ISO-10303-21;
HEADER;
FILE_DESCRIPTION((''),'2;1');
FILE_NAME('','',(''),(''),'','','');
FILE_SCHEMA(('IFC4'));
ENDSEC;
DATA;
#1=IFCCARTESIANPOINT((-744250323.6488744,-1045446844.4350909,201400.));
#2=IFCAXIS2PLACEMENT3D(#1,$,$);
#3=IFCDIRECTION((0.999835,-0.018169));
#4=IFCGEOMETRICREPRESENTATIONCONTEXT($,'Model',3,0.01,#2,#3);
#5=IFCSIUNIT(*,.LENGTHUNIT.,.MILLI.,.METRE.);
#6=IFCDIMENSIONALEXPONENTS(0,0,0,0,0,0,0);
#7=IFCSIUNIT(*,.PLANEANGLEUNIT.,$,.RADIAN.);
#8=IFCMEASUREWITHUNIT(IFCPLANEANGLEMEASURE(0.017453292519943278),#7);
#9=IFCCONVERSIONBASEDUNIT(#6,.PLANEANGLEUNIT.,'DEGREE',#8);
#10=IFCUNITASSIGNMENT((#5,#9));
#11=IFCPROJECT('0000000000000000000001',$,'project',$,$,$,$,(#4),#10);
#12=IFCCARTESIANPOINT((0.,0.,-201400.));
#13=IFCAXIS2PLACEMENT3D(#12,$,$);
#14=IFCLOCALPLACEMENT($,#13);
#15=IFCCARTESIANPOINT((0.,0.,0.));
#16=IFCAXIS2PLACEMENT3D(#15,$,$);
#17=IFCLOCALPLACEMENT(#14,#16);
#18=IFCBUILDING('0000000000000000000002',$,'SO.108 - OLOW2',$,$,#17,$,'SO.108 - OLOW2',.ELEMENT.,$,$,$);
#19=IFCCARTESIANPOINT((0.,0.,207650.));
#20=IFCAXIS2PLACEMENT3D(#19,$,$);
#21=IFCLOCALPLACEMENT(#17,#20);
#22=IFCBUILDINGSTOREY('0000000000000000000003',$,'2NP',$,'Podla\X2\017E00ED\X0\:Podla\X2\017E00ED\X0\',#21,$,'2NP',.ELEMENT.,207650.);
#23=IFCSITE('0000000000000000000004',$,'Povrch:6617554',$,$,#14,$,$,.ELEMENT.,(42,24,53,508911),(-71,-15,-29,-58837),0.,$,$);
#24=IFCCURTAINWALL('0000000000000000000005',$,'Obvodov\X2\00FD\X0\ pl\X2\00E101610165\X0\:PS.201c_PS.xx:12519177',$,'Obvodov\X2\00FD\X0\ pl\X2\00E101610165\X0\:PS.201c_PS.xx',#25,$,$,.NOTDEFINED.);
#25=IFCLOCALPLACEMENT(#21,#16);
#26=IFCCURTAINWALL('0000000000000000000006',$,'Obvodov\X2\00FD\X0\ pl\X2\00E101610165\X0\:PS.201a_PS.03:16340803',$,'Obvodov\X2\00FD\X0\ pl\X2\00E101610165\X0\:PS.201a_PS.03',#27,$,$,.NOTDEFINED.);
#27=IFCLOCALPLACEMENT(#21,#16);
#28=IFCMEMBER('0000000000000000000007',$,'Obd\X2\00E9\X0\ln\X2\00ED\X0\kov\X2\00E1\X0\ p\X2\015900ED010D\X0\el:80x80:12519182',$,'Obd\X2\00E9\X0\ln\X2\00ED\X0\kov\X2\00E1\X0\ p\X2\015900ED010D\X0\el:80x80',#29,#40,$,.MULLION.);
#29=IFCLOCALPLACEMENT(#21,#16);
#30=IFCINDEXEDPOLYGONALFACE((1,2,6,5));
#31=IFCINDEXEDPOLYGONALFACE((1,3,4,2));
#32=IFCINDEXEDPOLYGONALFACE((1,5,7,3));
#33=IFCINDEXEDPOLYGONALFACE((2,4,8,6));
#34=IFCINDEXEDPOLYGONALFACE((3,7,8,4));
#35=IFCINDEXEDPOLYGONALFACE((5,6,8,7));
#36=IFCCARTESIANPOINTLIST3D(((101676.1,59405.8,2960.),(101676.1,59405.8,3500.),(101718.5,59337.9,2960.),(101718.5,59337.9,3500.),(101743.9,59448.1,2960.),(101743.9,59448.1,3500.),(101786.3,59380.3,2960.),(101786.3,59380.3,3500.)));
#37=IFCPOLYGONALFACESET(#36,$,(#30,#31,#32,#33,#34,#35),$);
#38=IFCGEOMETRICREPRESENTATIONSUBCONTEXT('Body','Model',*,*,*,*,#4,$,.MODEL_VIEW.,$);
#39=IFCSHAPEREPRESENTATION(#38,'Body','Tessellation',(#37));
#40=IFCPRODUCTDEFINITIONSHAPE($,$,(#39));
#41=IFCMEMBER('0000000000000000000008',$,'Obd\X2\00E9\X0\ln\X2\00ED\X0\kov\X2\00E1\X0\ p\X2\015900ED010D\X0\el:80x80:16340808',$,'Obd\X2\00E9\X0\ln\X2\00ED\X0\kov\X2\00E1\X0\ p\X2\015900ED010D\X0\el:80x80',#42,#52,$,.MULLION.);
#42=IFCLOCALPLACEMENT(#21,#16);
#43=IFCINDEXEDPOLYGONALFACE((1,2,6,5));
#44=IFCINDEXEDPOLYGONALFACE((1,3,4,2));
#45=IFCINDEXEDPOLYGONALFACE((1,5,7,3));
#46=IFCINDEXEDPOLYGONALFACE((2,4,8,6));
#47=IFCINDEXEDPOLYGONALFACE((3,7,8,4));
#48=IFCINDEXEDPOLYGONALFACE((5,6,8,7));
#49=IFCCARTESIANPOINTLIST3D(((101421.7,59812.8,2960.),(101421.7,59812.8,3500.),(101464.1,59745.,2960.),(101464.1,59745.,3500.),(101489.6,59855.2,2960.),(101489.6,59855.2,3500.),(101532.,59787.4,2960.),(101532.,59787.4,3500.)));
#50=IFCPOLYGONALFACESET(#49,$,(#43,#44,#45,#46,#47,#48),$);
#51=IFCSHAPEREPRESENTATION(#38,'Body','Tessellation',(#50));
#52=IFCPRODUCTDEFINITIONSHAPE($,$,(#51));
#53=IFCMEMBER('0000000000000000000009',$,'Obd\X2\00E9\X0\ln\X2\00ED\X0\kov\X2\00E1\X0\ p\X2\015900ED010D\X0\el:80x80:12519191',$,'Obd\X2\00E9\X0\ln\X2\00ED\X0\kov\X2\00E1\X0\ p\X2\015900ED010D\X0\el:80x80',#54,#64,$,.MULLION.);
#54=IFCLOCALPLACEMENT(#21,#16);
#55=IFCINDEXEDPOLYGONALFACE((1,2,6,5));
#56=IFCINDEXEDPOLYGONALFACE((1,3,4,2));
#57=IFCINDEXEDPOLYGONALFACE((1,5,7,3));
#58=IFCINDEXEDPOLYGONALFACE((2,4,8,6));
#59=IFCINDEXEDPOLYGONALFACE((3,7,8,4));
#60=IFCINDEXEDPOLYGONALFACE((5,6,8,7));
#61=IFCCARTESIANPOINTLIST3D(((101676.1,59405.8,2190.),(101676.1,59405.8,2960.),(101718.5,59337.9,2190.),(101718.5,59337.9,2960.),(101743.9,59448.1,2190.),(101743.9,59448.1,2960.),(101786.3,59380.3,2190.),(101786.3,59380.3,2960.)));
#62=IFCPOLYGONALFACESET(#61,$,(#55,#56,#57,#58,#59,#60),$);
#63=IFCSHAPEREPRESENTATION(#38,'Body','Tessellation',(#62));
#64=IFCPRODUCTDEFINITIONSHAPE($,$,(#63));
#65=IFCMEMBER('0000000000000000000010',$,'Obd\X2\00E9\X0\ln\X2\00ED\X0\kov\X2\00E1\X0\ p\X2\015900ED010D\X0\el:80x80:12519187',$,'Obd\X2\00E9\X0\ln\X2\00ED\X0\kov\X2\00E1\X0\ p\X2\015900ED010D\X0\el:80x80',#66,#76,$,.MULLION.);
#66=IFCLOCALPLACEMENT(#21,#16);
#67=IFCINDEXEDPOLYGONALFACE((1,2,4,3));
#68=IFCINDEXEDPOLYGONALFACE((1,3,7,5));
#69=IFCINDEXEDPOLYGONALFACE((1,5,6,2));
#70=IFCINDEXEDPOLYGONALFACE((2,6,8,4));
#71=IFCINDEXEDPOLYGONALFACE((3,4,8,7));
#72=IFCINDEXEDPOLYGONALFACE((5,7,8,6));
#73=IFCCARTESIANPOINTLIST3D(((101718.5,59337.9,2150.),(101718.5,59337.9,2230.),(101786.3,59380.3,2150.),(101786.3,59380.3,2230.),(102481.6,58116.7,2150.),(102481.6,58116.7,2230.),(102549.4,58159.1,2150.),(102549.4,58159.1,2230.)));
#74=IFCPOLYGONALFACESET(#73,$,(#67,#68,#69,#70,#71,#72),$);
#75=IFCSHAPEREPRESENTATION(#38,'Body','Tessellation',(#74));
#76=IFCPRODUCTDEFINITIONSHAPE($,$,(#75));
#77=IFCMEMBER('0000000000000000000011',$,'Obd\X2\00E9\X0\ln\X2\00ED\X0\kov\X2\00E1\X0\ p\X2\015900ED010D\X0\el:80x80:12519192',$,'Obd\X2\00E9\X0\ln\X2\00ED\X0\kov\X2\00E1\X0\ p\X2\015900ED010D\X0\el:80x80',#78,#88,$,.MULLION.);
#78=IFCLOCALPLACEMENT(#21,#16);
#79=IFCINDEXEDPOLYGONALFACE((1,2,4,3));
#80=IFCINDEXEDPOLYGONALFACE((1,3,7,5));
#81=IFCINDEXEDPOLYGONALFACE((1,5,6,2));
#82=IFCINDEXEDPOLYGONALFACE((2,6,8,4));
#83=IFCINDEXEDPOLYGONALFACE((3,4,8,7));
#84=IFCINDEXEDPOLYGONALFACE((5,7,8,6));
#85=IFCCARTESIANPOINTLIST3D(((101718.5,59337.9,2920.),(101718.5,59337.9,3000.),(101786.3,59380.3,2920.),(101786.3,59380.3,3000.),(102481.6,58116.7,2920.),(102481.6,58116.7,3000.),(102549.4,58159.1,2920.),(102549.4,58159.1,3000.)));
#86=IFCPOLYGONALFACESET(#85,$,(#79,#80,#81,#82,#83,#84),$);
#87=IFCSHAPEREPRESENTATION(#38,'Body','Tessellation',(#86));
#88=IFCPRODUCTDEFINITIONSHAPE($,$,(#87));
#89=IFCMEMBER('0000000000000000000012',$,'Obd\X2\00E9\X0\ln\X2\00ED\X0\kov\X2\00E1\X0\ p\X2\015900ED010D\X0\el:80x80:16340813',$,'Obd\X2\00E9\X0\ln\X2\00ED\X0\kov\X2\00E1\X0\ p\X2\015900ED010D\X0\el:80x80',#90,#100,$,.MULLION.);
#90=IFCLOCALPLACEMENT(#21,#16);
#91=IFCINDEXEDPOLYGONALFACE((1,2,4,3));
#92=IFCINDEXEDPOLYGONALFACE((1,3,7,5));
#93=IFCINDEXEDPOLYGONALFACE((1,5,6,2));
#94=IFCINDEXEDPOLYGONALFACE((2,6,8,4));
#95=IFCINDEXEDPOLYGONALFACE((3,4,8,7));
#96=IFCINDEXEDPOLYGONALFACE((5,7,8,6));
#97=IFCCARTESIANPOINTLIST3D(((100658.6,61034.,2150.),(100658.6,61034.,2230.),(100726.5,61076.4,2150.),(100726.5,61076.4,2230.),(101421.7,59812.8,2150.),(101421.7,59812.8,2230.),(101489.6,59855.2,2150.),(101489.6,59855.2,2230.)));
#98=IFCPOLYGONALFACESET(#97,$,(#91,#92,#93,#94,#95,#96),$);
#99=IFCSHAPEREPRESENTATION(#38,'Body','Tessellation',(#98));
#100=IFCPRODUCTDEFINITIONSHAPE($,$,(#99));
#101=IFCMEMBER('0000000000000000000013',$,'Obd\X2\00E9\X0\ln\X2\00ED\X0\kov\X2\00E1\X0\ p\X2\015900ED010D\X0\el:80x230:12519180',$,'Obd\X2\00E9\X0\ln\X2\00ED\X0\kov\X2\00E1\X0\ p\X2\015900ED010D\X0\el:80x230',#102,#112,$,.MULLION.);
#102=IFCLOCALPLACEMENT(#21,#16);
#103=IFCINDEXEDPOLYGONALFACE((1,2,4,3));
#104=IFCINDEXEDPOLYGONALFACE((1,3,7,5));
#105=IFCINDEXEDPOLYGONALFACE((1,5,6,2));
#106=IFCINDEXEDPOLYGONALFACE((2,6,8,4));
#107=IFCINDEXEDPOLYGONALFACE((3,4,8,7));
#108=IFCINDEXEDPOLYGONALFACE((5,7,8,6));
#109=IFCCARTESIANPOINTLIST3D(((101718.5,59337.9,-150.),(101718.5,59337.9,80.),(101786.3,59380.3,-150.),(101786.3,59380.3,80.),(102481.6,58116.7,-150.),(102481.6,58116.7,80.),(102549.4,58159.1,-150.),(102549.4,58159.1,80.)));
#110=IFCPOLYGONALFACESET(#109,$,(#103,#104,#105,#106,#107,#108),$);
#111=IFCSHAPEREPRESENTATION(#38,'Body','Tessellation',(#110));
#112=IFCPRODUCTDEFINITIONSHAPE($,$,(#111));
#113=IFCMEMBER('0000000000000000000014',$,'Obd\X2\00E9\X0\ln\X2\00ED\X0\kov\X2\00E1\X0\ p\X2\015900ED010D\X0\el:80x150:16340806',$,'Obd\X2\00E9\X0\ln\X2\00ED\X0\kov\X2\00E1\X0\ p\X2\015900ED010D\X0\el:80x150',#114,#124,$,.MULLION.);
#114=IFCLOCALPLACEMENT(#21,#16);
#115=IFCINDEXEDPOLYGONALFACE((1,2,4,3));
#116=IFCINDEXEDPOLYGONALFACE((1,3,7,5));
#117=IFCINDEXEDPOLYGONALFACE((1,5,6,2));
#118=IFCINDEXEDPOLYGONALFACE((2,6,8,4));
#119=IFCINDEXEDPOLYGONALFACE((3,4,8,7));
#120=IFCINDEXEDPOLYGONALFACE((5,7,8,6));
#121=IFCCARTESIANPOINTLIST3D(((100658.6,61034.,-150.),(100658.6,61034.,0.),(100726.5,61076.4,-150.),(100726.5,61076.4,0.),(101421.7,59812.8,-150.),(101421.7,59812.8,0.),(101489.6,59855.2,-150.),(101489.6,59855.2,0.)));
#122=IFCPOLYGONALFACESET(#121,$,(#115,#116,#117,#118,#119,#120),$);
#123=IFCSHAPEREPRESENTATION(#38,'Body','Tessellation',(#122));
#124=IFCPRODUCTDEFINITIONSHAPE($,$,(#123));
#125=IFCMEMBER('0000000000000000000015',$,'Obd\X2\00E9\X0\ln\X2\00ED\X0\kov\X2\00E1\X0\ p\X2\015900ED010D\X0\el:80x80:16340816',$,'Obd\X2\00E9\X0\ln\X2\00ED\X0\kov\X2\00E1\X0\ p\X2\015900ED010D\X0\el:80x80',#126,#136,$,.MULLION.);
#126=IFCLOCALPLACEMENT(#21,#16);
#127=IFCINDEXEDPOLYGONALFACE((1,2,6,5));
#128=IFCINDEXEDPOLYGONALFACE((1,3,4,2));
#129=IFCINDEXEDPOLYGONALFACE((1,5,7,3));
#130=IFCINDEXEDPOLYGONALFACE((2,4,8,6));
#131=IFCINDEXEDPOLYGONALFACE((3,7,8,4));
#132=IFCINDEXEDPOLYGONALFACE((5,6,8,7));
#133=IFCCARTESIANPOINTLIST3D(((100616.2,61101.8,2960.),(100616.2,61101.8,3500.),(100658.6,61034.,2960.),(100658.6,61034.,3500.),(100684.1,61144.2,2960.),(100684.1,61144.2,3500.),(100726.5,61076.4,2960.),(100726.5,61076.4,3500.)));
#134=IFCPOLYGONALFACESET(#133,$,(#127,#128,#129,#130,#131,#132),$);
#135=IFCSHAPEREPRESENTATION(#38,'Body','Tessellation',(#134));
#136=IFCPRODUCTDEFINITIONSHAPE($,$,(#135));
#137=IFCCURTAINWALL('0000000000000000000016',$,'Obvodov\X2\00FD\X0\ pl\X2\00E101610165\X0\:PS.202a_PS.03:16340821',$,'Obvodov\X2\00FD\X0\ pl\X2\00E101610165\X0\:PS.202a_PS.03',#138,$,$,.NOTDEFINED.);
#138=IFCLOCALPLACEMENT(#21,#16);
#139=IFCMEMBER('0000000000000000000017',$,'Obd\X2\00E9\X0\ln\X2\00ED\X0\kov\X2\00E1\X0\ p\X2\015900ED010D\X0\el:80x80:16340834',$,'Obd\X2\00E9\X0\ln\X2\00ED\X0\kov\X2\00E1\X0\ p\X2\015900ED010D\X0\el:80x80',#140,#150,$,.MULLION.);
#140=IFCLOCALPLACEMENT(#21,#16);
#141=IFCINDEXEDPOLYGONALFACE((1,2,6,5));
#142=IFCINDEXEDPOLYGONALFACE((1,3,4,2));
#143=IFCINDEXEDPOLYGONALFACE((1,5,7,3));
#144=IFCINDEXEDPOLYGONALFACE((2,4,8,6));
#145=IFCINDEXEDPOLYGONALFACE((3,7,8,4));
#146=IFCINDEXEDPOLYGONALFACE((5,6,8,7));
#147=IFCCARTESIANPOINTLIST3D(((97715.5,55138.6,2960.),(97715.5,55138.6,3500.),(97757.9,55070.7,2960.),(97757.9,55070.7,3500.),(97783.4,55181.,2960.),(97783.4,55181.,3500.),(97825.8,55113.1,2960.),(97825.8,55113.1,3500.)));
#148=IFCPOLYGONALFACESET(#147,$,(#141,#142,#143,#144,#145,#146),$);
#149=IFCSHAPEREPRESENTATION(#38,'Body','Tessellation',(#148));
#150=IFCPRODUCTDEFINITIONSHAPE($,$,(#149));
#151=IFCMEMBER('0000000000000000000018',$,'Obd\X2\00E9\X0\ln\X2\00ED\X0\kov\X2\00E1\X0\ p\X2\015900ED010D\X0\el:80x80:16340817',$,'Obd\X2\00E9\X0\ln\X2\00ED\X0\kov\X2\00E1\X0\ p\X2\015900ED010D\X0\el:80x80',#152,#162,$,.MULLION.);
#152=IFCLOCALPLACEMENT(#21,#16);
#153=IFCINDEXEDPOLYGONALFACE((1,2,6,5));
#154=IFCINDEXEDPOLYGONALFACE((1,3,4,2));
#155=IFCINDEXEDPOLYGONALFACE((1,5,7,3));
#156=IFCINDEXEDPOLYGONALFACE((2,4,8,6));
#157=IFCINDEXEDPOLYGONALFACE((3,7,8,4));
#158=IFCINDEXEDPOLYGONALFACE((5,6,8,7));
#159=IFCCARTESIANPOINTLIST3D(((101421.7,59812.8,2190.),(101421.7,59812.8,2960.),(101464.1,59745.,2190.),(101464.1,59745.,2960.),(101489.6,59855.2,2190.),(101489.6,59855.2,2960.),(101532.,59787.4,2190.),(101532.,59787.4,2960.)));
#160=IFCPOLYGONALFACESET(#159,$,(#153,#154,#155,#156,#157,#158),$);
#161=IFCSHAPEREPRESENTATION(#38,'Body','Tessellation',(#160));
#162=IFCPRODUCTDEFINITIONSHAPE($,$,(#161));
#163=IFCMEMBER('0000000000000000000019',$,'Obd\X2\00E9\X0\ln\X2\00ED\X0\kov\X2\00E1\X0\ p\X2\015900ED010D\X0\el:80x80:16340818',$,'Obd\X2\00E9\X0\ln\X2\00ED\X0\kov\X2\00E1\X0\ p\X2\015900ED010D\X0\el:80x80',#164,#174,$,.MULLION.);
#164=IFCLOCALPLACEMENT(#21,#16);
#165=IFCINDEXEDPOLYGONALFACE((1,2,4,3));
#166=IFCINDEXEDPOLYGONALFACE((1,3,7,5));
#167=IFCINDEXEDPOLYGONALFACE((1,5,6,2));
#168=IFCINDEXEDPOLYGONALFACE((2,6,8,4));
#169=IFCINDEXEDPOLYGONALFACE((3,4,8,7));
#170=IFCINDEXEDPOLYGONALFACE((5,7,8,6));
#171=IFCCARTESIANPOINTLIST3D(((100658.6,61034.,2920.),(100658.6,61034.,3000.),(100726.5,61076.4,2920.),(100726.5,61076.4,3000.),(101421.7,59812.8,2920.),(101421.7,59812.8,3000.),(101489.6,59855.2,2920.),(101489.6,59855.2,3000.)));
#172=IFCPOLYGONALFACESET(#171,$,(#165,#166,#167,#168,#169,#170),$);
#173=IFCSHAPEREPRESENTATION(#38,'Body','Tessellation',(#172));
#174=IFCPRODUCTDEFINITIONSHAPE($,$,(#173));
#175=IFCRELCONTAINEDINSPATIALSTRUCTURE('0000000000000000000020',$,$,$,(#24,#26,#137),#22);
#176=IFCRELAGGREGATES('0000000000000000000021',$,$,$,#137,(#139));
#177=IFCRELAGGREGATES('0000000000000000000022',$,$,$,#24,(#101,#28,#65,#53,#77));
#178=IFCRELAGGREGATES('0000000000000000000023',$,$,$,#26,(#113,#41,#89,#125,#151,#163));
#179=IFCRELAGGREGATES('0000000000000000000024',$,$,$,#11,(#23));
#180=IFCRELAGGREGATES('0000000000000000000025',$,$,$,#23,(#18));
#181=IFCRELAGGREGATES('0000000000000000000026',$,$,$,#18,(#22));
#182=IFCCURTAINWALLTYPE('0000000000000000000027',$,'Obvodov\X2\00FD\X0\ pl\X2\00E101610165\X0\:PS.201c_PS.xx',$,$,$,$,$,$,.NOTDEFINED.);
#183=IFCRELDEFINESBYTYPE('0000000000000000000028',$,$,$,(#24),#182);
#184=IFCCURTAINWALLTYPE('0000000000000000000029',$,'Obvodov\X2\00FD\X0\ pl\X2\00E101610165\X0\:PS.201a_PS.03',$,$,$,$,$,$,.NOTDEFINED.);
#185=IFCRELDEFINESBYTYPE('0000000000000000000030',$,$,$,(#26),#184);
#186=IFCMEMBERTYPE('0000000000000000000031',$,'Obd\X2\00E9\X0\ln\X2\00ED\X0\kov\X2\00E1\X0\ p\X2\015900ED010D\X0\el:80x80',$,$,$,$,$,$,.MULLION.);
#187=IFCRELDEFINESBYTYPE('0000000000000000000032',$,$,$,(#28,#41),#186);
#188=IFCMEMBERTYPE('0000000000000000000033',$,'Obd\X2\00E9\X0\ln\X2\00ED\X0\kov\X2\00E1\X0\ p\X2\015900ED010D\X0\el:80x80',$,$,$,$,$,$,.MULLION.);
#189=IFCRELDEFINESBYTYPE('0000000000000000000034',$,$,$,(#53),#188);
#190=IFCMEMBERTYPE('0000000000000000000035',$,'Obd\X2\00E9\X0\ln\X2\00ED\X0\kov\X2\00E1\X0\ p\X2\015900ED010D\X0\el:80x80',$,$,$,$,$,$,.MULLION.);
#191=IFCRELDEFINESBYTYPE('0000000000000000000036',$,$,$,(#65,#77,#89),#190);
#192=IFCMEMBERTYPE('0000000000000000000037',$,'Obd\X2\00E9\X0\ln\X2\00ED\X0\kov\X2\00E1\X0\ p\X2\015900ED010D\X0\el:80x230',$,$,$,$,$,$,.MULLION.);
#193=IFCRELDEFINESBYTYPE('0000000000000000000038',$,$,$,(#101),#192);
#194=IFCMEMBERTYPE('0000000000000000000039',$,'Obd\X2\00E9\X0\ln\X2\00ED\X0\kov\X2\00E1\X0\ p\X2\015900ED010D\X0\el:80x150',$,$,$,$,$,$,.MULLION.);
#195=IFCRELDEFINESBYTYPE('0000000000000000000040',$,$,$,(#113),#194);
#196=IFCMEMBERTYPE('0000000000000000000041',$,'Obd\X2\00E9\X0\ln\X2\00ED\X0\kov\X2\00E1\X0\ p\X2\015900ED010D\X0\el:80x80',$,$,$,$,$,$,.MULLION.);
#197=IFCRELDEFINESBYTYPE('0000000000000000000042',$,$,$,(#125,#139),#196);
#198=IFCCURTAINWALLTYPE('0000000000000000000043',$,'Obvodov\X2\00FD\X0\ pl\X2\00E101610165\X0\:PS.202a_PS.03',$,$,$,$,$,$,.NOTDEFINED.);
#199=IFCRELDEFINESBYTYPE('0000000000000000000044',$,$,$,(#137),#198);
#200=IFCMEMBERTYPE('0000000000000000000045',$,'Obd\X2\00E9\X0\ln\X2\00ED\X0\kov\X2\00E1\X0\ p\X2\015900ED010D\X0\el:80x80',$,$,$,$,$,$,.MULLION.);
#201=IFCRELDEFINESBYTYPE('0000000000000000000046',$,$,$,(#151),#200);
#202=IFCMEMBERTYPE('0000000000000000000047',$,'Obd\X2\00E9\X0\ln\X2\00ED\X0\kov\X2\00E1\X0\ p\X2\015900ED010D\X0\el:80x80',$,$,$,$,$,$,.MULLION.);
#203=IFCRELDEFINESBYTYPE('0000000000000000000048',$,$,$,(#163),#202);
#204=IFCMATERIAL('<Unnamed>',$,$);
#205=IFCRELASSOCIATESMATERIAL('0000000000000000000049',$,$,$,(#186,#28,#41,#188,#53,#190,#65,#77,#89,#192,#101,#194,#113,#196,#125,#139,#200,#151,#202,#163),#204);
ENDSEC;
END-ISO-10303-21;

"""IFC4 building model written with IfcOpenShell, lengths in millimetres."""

from ifc_helpers import new_model, entity, si_unit, converted_unit, direction, frame, origin, place, context, subcontext, project, spatial, indexed_curve, outline, extrude, source, transform, mapped, material, type_object, type_shapes, element, aggregate, save


model = new_model("IFC4")

# Units and contexts
model_context = context("Model", 3, precision=0.01, world=frame((-744250323.6488744, -1045446844.4350909, 201400.0)), true_north=direction((0.999835, -0.018169)))
body_context = subcontext(model_context, "Body", "Model", "MODEL_VIEW")
ifc_project = project(units=[si_unit("LENGTHUNIT", "METRE", prefix="MILLI"), converted_unit("PLANEANGLEUNIT", "DEGREE", entity("IfcPlaneAngleMeasure", 0.017453292519943278), si_unit("PLANEANGLEUNIT", "RADIAN"), dimensions=[0, 0, 0, 0, 0, 0, 0])], contexts=[model_context])

# Site, building, storey
site_placement = place(None, frame((0.0, 0.0, -201400.0)))
site = spatial("IfcSite", under=ifc_project, at=site_placement, Name="Povrch:6617554", CompositionType="ELEMENT", RefLatitude=(42, 24, 53, 508911), RefLongitude=(-71, -15, -29, -58837), RefElevation=0.0)
building_placement = place(site_placement, origin())
building = spatial("IfcBuilding", under=site, at=building_placement, Name="SO.108 - OLOW2", LongName="SO.108 - OLOW2", CompositionType="ELEMENT")
storey_placement = place(building_placement, frame((0.0, 0.0, 207650.0)))
storey = spatial("IfcBuildingStorey", under=building, at=storey_placement, Name="2NP", ObjectType="Podlaží:Podlaží", LongName="2NP", CompositionType="ELEMENT", Elevation=207650.0)

# Shared definitions
ifc_material_1 = material(Name="<Unnamed>")

# Curtain walls
curtain_wall_type_1 = type_object("IfcCurtainWallType", Name="Obvodový plášť:PS.201c_PS.xx", PredefinedType="NOTDEFINED")
curtain_wall_1_placement = place(storey_placement, frame((0.0, 0.0, -207650.0)))
curtain_wall_1 = element("IfcCurtainWall", 1, at=curtain_wall_1_placement, inside=storey, type_object=curtain_wall_type_1, Name="Obvodový plášť:PS.201c_PS.xx:12519177", ObjectType="Obvodový plášť:PS.201c_PS.xx", PredefinedType="NOTDEFINED")
curtain_wall_type_2 = type_object("IfcCurtainWallType", Name="Obvodový plášť:PS.201a_PS.03", PredefinedType="NOTDEFINED")
curtain_wall_2_placement = place(storey_placement, frame((0.0, 0.0, -207650.0)))
curtain_wall_2 = element("IfcCurtainWall", 2, at=curtain_wall_2_placement, inside=storey, type_object=curtain_wall_type_2, Name="Obvodový plášť:PS.201a_PS.03:16340803", ObjectType="Obvodový plášť:PS.201a_PS.03", PredefinedType="NOTDEFINED")

# Members
member_type_1 = type_object("IfcMemberType", Name="Obdélníková příčel:80x80", PredefinedType="MULLION", material=ifc_material_1)
shared_shape_1 = source(origin(), body_context, "Body", "SweptSolid", [
    extrude(outline(indexed_curve([(-40.0, -40.0), (40.0, -40.0), (40.0, 40.0), (-40.0, 40.0), (-40.0, -40.0)], self_intersect=False)), frame((-40.0, 0.0, -540.0), z_axis=(0.0, 0.0, 1.0), x_axis=(-1.0, 0.0, 0.0)), (0.0, 0.0, 1.0), 540.0),
])
type_shapes(member_type_1, [shared_shape_1])
member_1_placement = place(curtain_wall_1_placement, frame((101710.0, 59426.9, 211150.0), z_axis=(0.0, 0.0, 1.0), x_axis=(-0.529919, 0.848048, 0.0)))
member_1 = element("IfcMember", 3, at=member_1_placement, type_object=member_type_1, material=ifc_material_1, Name="Obdélníková příčel:80x80:12519182", ObjectType="Obdélníková příčel:80x80", PredefinedType="MULLION", context=body_context, shape_type="MappedRepresentation", body=[
    mapped(shared_shape_1, transform((0.0, 0.0, 0.0), scale=1.0)),
])
member_2_placement = place(curtain_wall_2_placement, frame((101498.0, 59766.2, 211150.0), z_axis=(0.0, 0.0, 1.0), x_axis=(0.529919, -0.848048, 0.0)))
member_2 = element("IfcMember", 4, at=member_2_placement, type_object=member_type_1, material=ifc_material_1, Name="Obdélníková příčel:80x80:16340808", ObjectType="Obdélníková příčel:80x80", PredefinedType="MULLION", context=body_context, shape_type="MappedRepresentation", body=[
    mapped(shared_shape_1, transform((0.0, 0.0, 0.0), scale=1.0)),
])
member_type_2 = type_object("IfcMemberType", Name="Obdélníková příčel:80x80", PredefinedType="MULLION", material=ifc_material_1)
shared_shape_2 = source(origin(), body_context, "Body", "SweptSolid", [
    extrude(outline(indexed_curve([(-40.0, -40.0), (40.0, -40.0), (40.0, 40.0), (-40.0, 40.0), (-40.0, -40.0)], self_intersect=False)), frame((-40.0, 0.0, -770.0), z_axis=(0.0, 0.0, 1.0), x_axis=(-1.0, 0.0, 0.0)), (0.0, 0.0, 1.0), 770.0),
])
type_shapes(member_type_2, [shared_shape_2])
member_3_placement = place(curtain_wall_1_placement, frame((101710.0, 59426.9, 210610.0), z_axis=(0.0, 0.0, 1.0), x_axis=(-0.529919, 0.848048, 0.0)))
member_3 = element("IfcMember", 5, at=member_3_placement, type_object=member_type_2, material=ifc_material_1, Name="Obdélníková příčel:80x80:12519191", ObjectType="Obdélníková příčel:80x80", PredefinedType="MULLION", context=body_context, shape_type="MappedRepresentation", body=[
    mapped(shared_shape_2, transform((0.0, 0.0, 0.0), scale=1.0)),
])
member_type_3 = type_object("IfcMemberType", Name="Obdélníková příčel:80x80", PredefinedType="MULLION", material=ifc_material_1)
shared_shape_3 = source(origin(), body_context, "Body", "SweptSolid", [
    extrude(outline(indexed_curve([(-40.0, -40.0), (40.0, -40.0), (40.0, 40.0), (-40.0, 40.0), (-40.0, -40.0)], self_intersect=False)), frame((0.0, 0.0, -1440.0), z_axis=(0.0, 0.0, 1.0), x_axis=(-1.0, 0.0, 0.0)), (0.0, 0.0, 1.0), 1440.0),
])
type_shapes(member_type_3, [shared_shape_3])
member_4_placement = place(curtain_wall_1_placement, frame((102515.5, 58137.9, 209840.0), z_axis=(0.529919, -0.848048, 0.0), x_axis=(0.0, 0.0, 1.0)))
member_4 = element("IfcMember", 6, at=member_4_placement, type_object=member_type_3, material=ifc_material_1, Name="Obdélníková příčel:80x80:12519187", ObjectType="Obdélníková příčel:80x80", PredefinedType="MULLION", context=body_context, shape_type="MappedRepresentation", body=[
    mapped(shared_shape_3, transform((0.0, 0.0, 0.0), scale=1.0)),
])
member_5_placement = place(curtain_wall_1_placement, frame((102515.5, 58137.9, 210610.0), z_axis=(0.529919, -0.848048, 0.0), x_axis=(0.0, 0.0, 1.0)))
member_5 = element("IfcMember", 7, at=member_5_placement, type_object=member_type_3, material=ifc_material_1, Name="Obdélníková příčel:80x80:12519192", ObjectType="Obdélníková příčel:80x80", PredefinedType="MULLION", context=body_context, shape_type="MappedRepresentation", body=[
    mapped(shared_shape_3, transform((0.0, 0.0, 0.0), scale=1.0)),
])
member_6_placement = place(curtain_wall_2_placement, frame((100692.6, 61055.2, 209840.0), z_axis=(-0.529919, 0.848048, 0.0), x_axis=(0.0, 0.0, 1.0)))
member_6 = element("IfcMember", 8, at=member_6_placement, type_object=member_type_3, material=ifc_material_1, Name="Obdélníková příčel:80x80:16340813", ObjectType="Obdélníková příčel:80x80", PredefinedType="MULLION", context=body_context, shape_type="MappedRepresentation", body=[
    mapped(shared_shape_3, transform((0.0, 0.0, 0.0), scale=1.0)),
])
member_type_4 = type_object("IfcMemberType", Name="Obdélníková příčel:80x230", PredefinedType="MULLION", material=ifc_material_1)
shared_shape_4 = source(origin(), body_context, "Body", "SweptSolid", [
    extrude(outline(indexed_curve([(-115.0, -40.0), (115.0, -40.0), (115.0, 40.0), (-115.0, 40.0), (-115.0, -40.0)], self_intersect=False)), frame((-115.0, 0.0, -1440.0), z_axis=(0.0, 0.0, 1.0), x_axis=(-1.0, 0.0, 0.0)), (0.0, 0.0, 1.0), 1440.0),
])
type_shapes(member_type_4, [shared_shape_4])
member_7_placement = place(curtain_wall_1_placement, frame((101752.4, 59359.1, 207500.0), z_axis=(-0.529919, 0.848048, 0.0), x_axis=(0.0, 0.0, -1.0)))
member_7 = element("IfcMember", 9, at=member_7_placement, type_object=member_type_4, material=ifc_material_1, Name="Obdélníková příčel:80x230:12519180", ObjectType="Obdélníková příčel:80x230", PredefinedType="MULLION", context=body_context, shape_type="MappedRepresentation", body=[
    mapped(shared_shape_4, transform((0.0, 0.0, 0.0), scale=1.0)),
])
member_type_5 = type_object("IfcMemberType", Name="Obdélníková příčel:80x150", PredefinedType="MULLION", material=ifc_material_1)
shared_shape_5 = source(origin(), body_context, "Body", "SweptSolid", [
    extrude(outline(indexed_curve([(-75.0, -40.0), (75.0, -40.0), (75.0, 40.0), (-75.0, 40.0), (-75.0, -40.0)], self_intersect=False)), frame((-75.0, 0.0, -1440.0), z_axis=(0.0, 0.0, 1.0), x_axis=(-1.0, 0.0, 0.0)), (0.0, 0.0, 1.0), 1440.0),
])
type_shapes(member_type_5, [shared_shape_5])
member_8_placement = place(curtain_wall_2_placement, frame((101455.6, 59834.0, 207500.0), z_axis=(0.529919, -0.848048, 0.0), x_axis=(0.0, 0.0, -1.0)))
member_8 = element("IfcMember", 10, at=member_8_placement, type_object=member_type_5, material=ifc_material_1, Name="Obdélníková příčel:80x150:16340806", ObjectType="Obdélníková příčel:80x150", PredefinedType="MULLION", context=body_context, shape_type="MappedRepresentation", body=[
    mapped(shared_shape_5, transform((0.0, 0.0, 0.0), scale=1.0)),
])
member_type_6 = type_object("IfcMemberType", Name="Obdélníková příčel:80x80", PredefinedType="MULLION", material=ifc_material_1)
shared_shape_6 = source(origin(), body_context, "Body", "SweptSolid", [
    extrude(outline(indexed_curve([(-40.0, -40.0), (40.0, -40.0), (40.0, 40.0), (-40.0, 40.0), (-40.0, -40.0)], self_intersect=False)), frame((-40.0, 0.0, -540.0), z_axis=(0.0, 0.0, 1.0), x_axis=(-1.0, 0.0, 0.0)), (0.0, 0.0, 1.0), 540.0),
])
type_shapes(member_type_6, [shared_shape_6])
member_9_placement = place(curtain_wall_2_placement, frame((100650.2, 61123.0, 210610.0), z_axis=(0.0, 0.0, -1.0), x_axis=(-0.529919, 0.848048, 0.0)))
member_9 = element("IfcMember", 11, at=member_9_placement, type_object=member_type_6, material=ifc_material_1, Name="Obdélníková příčel:80x80:16340816", ObjectType="Obdélníková příčel:80x80", PredefinedType="MULLION", context=body_context, shape_type="MappedRepresentation", body=[
    mapped(shared_shape_6, transform((0.0, 0.0, 0.0), scale=1.0)),
])

# Curtain wall, member
curtain_wall_type_3 = type_object("IfcCurtainWallType", Name="Obvodový plášť:PS.202a_PS.03", PredefinedType="NOTDEFINED")
curtain_wall_3_placement = place(storey_placement, frame((0.0, 0.0, -207650.0)))
curtain_wall_3 = element("IfcCurtainWall", 12, at=curtain_wall_3_placement, inside=storey, type_object=curtain_wall_type_3, Name="Obvodový plášť:PS.202a_PS.03:16340821", ObjectType="Obvodový plášť:PS.202a_PS.03", PredefinedType="NOTDEFINED")
member_10_placement = place(curtain_wall_3_placement, frame((97791.8, 55091.9, 210610.0), z_axis=(0.0, 0.0, -1.0), x_axis=(0.529919, -0.848048, 0.0)))
member_10 = element("IfcMember", 13, at=member_10_placement, type_object=member_type_6, material=ifc_material_1, Name="Obdélníková příčel:80x80:16340834", ObjectType="Obdélníková příčel:80x80", PredefinedType="MULLION", context=body_context, shape_type="MappedRepresentation", body=[
    mapped(shared_shape_6, transform((0.0, 0.0, 0.0), scale=1.0)),
])
aggregate(curtain_wall_3, [member_10])

# Members
member_type_7 = type_object("IfcMemberType", Name="Obdélníková příčel:80x80", PredefinedType="MULLION", material=ifc_material_1)
shared_shape_7 = source(origin(), body_context, "Body", "SweptSolid", [
    extrude(outline(indexed_curve([(-40.0, -40.0), (40.0, -40.0), (40.0, 40.0), (-40.0, 40.0), (-40.0, -40.0)], self_intersect=False)), frame((-40.0, 0.0, -770.0), z_axis=(0.0, 0.0, 1.0), x_axis=(-1.0, 0.0, 0.0)), (0.0, 0.0, 1.0), 770.0),
])
type_shapes(member_type_7, [shared_shape_7])
member_11_placement = place(curtain_wall_2_placement, frame((101498.0, 59766.2, 210610.0), z_axis=(0.0, 0.0, 1.0), x_axis=(0.529919, -0.848048, 0.0)))
member_11 = element("IfcMember", 14, at=member_11_placement, type_object=member_type_7, material=ifc_material_1, Name="Obdélníková příčel:80x80:16340817", ObjectType="Obdélníková příčel:80x80", PredefinedType="MULLION", context=body_context, shape_type="MappedRepresentation", body=[
    mapped(shared_shape_7, transform((0.0, 0.0, 0.0), scale=1.0)),
])
member_type_8 = type_object("IfcMemberType", Name="Obdélníková příčel:80x80", PredefinedType="MULLION", material=ifc_material_1)
shared_shape_8 = source(origin(), body_context, "Body", "SweptSolid", [
    extrude(outline(indexed_curve([(-40.0, -40.0), (40.0, -40.0), (40.0, 40.0), (-40.0, 40.0), (-40.0, -40.0)], self_intersect=False)), frame((0.0, 0.0, -1440.0), z_axis=(0.0, 0.0, 1.0), x_axis=(-1.0, 0.0, 0.0)), (0.0, 0.0, 1.0), 1440.0),
])
type_shapes(member_type_8, [shared_shape_8])
member_12_placement = place(curtain_wall_2_placement, frame((100692.6, 61055.2, 210610.0), z_axis=(-0.529919, 0.848048, 0.0), x_axis=(0.0, 0.0, 1.0)))
member_12 = element("IfcMember", 15, at=member_12_placement, type_object=member_type_8, material=ifc_material_1, Name="Obdélníková příčel:80x80:16340818", ObjectType="Obdélníková příčel:80x80", PredefinedType="MULLION", context=body_context, shape_type="MappedRepresentation", body=[
    mapped(shared_shape_8, transform((0.0, 0.0, 0.0), scale=1.0)),
])

aggregate(curtain_wall_1, [member_7, member_1, member_4, member_3, member_5])

aggregate(curtain_wall_2, [member_8, member_2, member_6, member_9, member_11, member_12])

save(model, "model.ifc")
